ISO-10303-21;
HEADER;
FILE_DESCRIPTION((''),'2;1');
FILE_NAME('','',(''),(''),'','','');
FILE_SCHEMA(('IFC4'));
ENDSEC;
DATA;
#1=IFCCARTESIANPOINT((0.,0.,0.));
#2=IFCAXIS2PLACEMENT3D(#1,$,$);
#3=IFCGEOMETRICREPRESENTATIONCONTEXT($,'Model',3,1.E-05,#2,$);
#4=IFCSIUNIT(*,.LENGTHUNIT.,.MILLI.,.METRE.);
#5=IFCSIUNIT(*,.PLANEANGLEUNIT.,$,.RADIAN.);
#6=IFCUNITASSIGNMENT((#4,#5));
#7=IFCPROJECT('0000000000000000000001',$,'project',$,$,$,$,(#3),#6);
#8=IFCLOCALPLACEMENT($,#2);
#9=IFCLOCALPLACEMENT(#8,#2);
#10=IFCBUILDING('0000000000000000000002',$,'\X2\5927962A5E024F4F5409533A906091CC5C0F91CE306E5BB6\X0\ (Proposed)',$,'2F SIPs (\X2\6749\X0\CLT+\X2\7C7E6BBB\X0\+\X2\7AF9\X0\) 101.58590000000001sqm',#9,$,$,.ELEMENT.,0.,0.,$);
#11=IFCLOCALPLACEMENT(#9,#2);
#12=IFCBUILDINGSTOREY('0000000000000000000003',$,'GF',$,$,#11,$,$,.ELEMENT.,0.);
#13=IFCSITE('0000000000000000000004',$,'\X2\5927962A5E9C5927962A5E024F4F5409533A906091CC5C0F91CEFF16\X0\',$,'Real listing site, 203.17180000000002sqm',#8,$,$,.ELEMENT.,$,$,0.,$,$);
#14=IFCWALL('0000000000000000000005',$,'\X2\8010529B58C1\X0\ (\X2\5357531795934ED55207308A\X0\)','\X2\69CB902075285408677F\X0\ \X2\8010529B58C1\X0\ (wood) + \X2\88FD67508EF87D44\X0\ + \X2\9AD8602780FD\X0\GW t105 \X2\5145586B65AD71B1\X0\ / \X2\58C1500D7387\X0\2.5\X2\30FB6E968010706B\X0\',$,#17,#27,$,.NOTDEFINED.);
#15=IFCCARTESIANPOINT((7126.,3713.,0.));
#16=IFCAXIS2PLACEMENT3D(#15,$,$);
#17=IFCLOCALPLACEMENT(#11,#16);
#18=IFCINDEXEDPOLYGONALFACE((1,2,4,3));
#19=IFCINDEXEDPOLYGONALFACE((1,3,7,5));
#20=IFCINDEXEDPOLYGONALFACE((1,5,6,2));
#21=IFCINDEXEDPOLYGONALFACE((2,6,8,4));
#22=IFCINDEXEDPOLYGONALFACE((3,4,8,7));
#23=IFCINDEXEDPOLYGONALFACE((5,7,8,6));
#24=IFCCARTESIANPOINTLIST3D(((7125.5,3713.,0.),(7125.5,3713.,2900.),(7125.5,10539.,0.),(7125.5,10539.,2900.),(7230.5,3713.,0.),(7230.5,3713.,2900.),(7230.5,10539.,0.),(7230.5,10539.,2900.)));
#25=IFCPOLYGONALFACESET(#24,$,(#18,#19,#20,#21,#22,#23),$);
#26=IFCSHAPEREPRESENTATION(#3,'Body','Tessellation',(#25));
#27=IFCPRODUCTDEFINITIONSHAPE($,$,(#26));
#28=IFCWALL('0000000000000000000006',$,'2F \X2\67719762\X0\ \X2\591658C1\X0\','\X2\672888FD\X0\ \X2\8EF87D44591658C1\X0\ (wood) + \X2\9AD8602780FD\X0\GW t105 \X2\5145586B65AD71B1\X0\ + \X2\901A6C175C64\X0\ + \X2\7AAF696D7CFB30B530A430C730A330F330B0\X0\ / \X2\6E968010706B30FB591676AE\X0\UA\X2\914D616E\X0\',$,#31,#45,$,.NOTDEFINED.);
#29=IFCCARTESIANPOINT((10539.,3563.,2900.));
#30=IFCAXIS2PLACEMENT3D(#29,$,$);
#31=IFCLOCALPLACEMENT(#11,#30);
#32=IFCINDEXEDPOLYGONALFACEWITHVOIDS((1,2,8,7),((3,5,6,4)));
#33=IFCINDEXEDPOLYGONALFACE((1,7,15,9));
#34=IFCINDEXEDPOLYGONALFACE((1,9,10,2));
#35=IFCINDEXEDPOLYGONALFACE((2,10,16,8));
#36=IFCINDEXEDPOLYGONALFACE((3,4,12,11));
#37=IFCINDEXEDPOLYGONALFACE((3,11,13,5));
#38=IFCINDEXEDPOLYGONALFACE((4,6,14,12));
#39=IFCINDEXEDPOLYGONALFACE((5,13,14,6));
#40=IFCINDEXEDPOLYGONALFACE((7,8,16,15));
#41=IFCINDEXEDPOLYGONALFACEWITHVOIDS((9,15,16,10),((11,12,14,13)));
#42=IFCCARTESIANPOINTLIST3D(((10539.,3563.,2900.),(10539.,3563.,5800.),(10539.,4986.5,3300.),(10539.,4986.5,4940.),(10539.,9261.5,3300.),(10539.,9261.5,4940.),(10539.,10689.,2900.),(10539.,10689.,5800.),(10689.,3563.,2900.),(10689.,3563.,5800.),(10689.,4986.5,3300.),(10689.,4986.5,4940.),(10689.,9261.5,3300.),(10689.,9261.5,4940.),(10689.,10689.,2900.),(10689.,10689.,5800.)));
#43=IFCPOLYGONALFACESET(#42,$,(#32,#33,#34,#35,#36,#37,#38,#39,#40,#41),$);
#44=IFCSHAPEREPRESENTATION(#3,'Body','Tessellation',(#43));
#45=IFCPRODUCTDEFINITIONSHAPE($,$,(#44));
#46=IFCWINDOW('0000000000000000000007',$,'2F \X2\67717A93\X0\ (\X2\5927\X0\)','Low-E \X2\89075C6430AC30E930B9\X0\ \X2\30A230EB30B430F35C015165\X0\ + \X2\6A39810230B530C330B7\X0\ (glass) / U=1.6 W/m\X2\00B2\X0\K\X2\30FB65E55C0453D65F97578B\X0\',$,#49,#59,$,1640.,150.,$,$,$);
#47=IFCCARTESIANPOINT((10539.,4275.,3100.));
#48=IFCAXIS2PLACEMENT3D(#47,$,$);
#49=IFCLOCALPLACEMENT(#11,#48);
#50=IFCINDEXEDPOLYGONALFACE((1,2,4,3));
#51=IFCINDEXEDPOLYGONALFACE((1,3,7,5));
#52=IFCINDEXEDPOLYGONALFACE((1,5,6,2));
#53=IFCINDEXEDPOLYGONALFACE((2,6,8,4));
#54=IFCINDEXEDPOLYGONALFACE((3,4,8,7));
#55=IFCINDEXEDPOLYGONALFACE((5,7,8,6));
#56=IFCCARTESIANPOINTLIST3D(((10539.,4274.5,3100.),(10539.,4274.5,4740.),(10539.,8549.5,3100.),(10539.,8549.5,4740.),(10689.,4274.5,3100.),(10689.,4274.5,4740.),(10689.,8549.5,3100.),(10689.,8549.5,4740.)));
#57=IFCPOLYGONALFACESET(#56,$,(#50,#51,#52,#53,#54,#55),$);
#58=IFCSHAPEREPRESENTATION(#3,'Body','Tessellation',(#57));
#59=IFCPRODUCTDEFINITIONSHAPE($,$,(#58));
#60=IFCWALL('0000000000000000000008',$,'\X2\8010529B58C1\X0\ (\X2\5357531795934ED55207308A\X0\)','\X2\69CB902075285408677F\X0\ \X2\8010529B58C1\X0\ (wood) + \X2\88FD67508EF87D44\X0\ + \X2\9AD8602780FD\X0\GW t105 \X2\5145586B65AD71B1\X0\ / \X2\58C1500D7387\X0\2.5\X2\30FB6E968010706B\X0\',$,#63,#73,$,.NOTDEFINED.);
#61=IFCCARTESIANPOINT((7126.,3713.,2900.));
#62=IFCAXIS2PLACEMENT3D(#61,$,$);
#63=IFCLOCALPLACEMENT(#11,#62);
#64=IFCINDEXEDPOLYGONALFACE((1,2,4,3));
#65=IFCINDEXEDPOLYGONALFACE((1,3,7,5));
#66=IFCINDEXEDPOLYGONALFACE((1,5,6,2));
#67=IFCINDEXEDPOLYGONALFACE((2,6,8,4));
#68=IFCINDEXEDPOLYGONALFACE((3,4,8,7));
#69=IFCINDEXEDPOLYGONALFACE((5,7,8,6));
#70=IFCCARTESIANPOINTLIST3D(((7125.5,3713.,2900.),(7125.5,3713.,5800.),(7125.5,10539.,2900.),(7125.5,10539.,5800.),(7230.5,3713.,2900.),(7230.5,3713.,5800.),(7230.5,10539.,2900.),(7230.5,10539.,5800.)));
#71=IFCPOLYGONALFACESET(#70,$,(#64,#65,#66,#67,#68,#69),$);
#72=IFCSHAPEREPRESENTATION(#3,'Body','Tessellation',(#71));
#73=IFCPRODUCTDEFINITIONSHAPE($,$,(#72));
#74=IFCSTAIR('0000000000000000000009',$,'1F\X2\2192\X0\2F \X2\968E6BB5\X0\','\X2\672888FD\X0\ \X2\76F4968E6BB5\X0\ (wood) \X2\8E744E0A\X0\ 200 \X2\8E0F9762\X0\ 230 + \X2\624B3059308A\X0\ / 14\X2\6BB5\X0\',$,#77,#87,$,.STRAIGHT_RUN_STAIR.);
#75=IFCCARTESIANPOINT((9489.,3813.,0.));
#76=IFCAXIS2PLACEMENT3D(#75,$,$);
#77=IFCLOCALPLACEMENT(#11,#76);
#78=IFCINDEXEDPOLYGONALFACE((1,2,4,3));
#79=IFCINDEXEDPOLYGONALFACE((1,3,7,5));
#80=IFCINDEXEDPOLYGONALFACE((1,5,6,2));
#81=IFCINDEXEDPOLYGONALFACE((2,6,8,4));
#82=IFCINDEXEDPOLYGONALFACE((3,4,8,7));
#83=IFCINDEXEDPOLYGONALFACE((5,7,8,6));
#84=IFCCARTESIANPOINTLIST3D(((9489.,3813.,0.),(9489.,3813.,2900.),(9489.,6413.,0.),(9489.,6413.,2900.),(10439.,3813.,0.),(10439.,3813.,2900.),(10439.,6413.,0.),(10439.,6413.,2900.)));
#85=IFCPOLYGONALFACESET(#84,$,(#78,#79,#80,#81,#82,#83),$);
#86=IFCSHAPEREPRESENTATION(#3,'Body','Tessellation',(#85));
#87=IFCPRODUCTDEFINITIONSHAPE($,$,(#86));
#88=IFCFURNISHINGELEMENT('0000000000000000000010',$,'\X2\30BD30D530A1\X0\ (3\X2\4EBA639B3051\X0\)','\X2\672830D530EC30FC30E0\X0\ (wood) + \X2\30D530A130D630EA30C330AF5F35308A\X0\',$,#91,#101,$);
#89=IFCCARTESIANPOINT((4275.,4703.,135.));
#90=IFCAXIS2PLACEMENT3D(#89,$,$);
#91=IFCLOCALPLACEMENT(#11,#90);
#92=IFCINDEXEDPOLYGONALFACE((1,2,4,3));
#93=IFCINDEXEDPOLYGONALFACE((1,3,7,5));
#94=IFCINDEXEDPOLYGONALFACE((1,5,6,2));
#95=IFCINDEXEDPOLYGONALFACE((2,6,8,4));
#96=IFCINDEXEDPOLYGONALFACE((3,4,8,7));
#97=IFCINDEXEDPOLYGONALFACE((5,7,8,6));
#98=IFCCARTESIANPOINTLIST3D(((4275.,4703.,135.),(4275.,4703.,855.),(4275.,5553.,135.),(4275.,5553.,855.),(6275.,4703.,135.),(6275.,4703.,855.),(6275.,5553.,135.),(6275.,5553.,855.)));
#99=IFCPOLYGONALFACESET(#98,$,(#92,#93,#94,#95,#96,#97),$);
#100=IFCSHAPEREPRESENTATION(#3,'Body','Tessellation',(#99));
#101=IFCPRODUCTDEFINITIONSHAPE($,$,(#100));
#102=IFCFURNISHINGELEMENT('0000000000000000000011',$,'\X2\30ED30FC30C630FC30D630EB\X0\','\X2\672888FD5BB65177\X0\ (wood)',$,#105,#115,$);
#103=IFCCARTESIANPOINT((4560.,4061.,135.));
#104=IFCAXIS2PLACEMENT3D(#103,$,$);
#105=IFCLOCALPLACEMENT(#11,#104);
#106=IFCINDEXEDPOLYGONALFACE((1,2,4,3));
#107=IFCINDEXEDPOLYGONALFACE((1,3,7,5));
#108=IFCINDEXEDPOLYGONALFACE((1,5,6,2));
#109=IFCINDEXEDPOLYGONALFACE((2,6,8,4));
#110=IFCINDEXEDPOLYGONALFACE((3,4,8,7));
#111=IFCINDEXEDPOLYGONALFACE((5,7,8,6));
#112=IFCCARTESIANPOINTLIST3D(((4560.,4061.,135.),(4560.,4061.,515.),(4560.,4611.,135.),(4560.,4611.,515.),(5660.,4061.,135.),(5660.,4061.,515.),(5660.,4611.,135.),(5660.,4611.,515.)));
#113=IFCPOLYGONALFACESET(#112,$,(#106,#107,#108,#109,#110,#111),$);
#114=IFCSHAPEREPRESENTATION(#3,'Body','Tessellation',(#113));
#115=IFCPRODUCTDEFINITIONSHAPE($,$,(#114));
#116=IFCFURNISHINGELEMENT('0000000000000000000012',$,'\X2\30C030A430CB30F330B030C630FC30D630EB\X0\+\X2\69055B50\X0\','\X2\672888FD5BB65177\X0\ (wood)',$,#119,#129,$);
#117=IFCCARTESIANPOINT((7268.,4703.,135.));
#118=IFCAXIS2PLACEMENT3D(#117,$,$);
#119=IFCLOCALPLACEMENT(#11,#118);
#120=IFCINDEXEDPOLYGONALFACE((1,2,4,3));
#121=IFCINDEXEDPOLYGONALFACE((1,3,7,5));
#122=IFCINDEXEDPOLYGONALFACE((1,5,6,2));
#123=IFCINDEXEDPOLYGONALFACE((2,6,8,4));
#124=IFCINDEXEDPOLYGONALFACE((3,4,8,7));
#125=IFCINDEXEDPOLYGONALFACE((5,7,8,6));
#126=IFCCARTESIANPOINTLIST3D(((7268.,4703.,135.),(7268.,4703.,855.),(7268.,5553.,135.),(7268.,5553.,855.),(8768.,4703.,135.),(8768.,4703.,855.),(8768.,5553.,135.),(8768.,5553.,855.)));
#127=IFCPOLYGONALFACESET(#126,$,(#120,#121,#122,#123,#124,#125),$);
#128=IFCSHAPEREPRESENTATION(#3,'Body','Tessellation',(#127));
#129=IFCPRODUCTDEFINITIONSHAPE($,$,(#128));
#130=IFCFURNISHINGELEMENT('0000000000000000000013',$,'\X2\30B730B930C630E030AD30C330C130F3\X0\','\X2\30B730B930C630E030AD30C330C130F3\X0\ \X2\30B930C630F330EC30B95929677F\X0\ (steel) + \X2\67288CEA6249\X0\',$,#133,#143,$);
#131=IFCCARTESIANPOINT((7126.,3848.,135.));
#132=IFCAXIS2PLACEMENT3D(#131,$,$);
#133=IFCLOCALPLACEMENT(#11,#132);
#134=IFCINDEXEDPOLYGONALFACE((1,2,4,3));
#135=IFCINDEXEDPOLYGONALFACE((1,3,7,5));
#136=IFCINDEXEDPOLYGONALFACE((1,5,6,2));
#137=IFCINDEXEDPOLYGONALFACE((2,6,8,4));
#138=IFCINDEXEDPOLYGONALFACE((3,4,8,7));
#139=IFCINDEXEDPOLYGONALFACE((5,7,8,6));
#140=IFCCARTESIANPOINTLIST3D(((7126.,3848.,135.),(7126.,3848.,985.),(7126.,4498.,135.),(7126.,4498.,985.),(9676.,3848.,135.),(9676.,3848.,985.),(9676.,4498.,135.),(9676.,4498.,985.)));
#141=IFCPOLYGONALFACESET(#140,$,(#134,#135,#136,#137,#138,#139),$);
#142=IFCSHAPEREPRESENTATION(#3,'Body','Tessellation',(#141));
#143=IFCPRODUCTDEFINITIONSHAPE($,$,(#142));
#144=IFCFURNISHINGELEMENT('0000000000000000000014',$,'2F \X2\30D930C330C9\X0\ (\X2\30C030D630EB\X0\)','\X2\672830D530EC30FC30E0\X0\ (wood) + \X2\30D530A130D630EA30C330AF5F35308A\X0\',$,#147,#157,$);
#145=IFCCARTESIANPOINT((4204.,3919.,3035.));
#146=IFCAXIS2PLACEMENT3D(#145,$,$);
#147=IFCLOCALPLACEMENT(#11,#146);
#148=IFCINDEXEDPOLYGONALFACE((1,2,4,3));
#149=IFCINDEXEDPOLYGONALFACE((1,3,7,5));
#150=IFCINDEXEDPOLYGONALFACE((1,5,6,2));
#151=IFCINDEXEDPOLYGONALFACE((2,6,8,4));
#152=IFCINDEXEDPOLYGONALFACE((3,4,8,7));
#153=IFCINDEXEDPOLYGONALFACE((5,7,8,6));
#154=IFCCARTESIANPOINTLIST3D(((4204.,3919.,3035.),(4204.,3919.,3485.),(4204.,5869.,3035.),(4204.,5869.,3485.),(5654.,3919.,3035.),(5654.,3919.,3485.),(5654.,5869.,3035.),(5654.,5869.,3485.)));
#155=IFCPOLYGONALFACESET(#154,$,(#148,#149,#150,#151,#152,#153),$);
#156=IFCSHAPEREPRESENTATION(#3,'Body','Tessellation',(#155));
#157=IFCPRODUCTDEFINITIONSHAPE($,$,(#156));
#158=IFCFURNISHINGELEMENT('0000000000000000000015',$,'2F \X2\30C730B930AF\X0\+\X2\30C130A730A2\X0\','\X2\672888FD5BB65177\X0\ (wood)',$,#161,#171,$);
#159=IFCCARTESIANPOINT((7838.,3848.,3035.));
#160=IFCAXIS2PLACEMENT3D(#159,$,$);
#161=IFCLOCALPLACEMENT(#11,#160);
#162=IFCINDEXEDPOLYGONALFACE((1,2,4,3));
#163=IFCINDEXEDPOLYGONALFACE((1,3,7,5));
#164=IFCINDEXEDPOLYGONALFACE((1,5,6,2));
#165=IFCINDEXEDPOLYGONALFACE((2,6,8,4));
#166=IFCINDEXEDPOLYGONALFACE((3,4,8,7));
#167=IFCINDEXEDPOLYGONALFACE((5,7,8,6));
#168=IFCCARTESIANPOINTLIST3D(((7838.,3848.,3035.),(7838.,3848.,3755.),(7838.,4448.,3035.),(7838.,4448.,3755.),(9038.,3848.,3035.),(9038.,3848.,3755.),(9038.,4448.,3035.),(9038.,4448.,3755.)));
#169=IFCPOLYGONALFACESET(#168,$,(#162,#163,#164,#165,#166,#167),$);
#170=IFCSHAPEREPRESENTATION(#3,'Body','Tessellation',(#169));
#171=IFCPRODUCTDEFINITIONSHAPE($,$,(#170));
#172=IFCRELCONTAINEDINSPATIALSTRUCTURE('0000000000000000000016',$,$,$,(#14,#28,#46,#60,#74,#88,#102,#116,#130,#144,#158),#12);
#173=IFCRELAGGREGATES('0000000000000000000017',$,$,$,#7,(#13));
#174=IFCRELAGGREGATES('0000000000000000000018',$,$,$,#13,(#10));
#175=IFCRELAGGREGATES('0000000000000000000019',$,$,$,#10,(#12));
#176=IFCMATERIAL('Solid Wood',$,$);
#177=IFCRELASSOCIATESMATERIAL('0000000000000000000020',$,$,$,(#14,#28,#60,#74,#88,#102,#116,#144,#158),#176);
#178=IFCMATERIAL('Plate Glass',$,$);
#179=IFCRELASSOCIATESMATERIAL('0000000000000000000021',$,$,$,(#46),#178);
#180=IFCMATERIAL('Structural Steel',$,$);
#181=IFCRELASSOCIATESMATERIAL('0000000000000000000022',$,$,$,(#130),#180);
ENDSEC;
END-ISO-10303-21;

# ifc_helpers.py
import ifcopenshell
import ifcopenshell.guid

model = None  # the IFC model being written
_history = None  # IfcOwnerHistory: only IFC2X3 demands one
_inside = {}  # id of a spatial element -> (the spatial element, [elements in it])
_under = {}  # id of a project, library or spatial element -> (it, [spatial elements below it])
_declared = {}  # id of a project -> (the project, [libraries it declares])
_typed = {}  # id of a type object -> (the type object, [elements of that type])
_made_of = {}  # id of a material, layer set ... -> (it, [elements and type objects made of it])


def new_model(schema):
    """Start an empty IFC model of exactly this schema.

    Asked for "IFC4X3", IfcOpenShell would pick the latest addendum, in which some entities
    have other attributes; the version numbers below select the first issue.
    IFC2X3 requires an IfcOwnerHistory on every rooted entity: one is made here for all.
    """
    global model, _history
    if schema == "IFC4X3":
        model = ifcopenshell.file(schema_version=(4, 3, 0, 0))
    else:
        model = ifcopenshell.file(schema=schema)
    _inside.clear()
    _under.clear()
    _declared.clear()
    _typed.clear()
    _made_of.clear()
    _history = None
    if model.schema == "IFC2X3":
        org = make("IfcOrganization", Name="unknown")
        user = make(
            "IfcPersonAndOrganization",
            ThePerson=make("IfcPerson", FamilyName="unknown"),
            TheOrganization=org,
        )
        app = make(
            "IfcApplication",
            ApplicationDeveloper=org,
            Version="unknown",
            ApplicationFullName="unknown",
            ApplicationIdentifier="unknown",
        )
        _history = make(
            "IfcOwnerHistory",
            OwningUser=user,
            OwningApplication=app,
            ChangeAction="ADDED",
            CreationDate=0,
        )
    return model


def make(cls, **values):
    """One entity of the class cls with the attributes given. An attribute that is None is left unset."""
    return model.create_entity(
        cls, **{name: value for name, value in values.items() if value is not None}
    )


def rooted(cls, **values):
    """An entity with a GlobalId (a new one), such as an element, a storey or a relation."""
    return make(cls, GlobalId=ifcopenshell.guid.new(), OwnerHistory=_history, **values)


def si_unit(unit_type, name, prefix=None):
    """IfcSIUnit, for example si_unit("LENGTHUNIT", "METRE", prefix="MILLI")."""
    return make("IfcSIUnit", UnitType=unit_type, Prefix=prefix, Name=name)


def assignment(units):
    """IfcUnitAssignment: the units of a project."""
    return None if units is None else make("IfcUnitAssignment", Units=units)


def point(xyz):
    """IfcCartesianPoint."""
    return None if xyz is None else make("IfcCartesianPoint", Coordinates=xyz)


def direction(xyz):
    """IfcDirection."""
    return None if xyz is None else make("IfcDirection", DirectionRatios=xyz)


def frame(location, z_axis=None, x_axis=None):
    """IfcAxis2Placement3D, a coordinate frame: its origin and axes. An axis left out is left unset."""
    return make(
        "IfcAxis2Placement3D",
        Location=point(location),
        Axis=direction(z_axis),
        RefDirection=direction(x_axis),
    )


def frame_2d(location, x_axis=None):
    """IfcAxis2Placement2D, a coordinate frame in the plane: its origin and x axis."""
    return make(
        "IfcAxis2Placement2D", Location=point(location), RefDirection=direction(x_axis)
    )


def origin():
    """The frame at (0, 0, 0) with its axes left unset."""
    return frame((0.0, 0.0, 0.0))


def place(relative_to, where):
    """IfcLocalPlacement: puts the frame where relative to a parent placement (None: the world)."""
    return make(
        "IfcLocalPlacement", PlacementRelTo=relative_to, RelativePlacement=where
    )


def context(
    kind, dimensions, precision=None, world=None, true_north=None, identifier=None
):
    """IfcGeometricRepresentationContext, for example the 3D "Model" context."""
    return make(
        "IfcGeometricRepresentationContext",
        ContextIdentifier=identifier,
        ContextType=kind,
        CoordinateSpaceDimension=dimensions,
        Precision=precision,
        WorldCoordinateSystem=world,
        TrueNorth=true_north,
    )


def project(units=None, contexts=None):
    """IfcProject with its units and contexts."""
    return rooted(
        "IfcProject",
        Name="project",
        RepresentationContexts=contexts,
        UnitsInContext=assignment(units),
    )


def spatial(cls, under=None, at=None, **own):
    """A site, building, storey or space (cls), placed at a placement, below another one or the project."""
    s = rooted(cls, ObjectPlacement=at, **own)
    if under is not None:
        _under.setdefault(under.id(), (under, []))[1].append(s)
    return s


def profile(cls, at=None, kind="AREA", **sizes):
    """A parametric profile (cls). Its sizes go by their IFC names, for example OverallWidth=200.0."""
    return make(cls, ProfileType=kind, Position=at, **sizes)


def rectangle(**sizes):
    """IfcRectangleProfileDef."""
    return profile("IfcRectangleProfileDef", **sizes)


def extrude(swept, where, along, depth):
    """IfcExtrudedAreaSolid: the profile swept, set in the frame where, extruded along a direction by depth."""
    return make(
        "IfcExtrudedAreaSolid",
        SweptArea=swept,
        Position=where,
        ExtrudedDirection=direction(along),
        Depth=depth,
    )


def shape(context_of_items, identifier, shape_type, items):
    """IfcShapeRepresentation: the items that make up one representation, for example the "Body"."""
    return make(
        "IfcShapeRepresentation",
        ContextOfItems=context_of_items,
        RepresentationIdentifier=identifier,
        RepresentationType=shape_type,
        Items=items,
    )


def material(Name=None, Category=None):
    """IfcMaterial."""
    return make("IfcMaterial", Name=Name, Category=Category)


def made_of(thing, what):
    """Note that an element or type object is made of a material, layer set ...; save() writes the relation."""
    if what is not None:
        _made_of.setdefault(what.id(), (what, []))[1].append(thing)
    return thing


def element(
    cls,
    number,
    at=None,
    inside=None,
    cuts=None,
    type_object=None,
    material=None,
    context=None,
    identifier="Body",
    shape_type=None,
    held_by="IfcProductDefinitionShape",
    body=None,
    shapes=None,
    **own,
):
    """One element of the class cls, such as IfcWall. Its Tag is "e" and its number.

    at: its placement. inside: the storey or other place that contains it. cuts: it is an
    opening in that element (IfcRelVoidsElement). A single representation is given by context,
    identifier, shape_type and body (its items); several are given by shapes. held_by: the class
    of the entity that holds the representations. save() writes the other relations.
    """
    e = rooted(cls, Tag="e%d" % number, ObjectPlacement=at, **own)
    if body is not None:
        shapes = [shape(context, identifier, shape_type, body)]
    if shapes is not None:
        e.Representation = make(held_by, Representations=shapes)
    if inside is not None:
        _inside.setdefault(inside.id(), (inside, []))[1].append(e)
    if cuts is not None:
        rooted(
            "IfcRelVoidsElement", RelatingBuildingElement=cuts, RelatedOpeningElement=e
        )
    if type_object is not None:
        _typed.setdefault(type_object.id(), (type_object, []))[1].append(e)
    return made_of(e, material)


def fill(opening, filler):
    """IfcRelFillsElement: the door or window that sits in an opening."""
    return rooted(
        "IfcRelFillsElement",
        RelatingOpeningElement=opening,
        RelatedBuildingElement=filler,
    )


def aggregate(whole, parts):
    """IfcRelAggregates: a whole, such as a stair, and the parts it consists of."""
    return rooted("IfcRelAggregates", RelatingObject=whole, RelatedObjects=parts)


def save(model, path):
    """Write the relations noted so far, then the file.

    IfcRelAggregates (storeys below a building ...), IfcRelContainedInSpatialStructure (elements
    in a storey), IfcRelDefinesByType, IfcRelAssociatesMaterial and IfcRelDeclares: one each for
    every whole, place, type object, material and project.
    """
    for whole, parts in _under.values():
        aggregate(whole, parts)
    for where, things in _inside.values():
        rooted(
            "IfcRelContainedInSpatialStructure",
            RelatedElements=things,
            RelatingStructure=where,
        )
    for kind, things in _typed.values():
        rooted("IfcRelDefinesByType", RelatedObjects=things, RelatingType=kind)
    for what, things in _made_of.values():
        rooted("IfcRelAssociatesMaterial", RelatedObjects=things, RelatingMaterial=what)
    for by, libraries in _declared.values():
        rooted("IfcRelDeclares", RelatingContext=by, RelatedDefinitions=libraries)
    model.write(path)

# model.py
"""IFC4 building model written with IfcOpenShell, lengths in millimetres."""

from ifc_helpers import new_model, si_unit, frame, frame_2d, origin, place, context, project, spatial, rectangle, extrude, material, element, fill, save


model = new_model("IFC4")

# Units and contexts
model_context = context("Model", 3, precision=1e-05, world=origin())
ifc_project = project(units=[si_unit("LENGTHUNIT", "METRE", prefix="MILLI"), si_unit("PLANEANGLEUNIT", "RADIAN")], contexts=[model_context])

# Site, building, storey
site_placement = place(None, origin())
site = spatial("IfcSite", under=ifc_project, at=site_placement, Name="大阪府大阪市住吉区遠里小野６", ObjectType="Real listing site, 203.17180000000002sqm", CompositionType="ELEMENT", RefElevation=0.0)
building_placement = place(site_placement, origin())
building = spatial("IfcBuilding", under=site, at=building_placement, Name="大阪市住吉区遠里小野の家 (Proposed)", ObjectType="2F SIPs (杉CLT+籾殻+竹) 101.58590000000001sqm", CompositionType="ELEMENT", ElevationOfRefHeight=0.0, ElevationOfTerrain=0.0)
storey_placement = place(building_placement, origin())
storey = spatial("IfcBuildingStorey", under=building, at=storey_placement, Name="GF", CompositionType="ELEMENT", Elevation=0.0)

# Shared definitions
ifc_material_1 = material(Name="Solid Wood")
ifc_material_2 = material(Name="Plate Glass")

# Wall
wall_1_placement = place(storey_placement, frame((7126.0, 3713.0, 0.0)))
element("IfcWall", 1, at=wall_1_placement, inside=storey, material=ifc_material_1, Name="耐力壁 (南北間仕切り)", Description="構造用合板 耐力壁 (wood) + 製材軸組 + 高性能GW t105 充填断熱 / 壁倍率2.5・準耐火", PredefinedType="NOTDEFINED", context=model_context, shape_type="SweptSolid", body=[
    extrude(rectangle(XDim=105.0, YDim=6826.0, at=frame_2d((52.0, 3413.0))), frame((7126.0, 3713.0, 0.0)), (0.0, 0.0, 1.0), 2900.0),
])

# Wall, opening, window
wall_2_placement = place(storey_placement, frame((10539.0, 3563.0, 2900.0)))
wall_2 = element("IfcWall", 2, at=wall_2_placement, inside=storey, material=ifc_material_1, Name="2F 東面 外壁", Description="木製 軸組外壁 (wood) + 高性能GW t105 充填断熱 + 通気層 + 窯業系サイディング / 準耐火・外皮UA配慮", PredefinedType="NOTDEFINED", context=model_context, shape_type="SweptSolid", body=[
    extrude(rectangle(XDim=150.0, YDim=7126.0, at=frame_2d((75.0, 3563.0))), frame((10539.0, 3563.0, 2900.0)), (0.0, 0.0, 1.0), 2900.0),
])
opening_1_placement = place(storey_placement, frame((10539.0, 4275.0, 3100.0)))
opening_1 = element("IfcOpeningElement", 3, at=opening_1_placement, cuts=wall_2, PredefinedType="NOTDEFINED", context=model_context, shape_type="SweptSolid", body=[
    extrude(rectangle(XDim=150.0, YDim=4275.0, at=frame_2d((75.0, 2137.0))), frame((10539.0, 4275.0, 3100.0)), (0.0, 0.0, 1.0), 1640.0),
])
window_1_placement = place(storey_placement, frame((10539.0, 4275.0, 3100.0)))
window_1 = element("IfcWindow", 4, at=window_1_placement, inside=storey, material=ifc_material_2, Name="2F 東窓 (大)", Description="Low-E 複層ガラス アルゴン封入 + 樹脂サッシ (glass) / U=1.6 W/m²K・日射取得型", OverallHeight=1640.0, OverallWidth=150.0, context=model_context, shape_type="SweptSolid", body=[
    extrude(rectangle(XDim=150.0, YDim=4275.0, at=frame_2d((75.0, 2137.0))), frame((10539.0, 4275.0, 3100.0)), (0.0, 0.0, 1.0), 1640.0),
])
fill(opening_1, window_1)

# Wall
wall_3_placement = place(storey_placement, frame((7126.0, 3713.0, 2900.0)))
element("IfcWall", 5, at=wall_3_placement, inside=storey, material=ifc_material_1, Name="耐力壁 (南北間仕切り)", Description="構造用合板 耐力壁 (wood) + 製材軸組 + 高性能GW t105 充填断熱 / 壁倍率2.5・準耐火", PredefinedType="NOTDEFINED", context=model_context, shape_type="SweptSolid", body=[
    extrude(rectangle(XDim=105.0, YDim=6826.0, at=frame_2d((52.0, 3413.0))), frame((7126.0, 3713.0, 2900.0)), (0.0, 0.0, 1.0), 2900.0),
])

# Stair
stair_placement = place(storey_placement, frame((9489.0, 3813.0, 0.0)))
element("IfcStair", 6, at=stair_placement, inside=storey, material=ifc_material_1, Name="1F→2F 階段", Description="木製 直階段 (wood) 蹴上 200 踏面 230 + 手すり / 14段", PredefinedType="STRAIGHT_RUN_STAIR", context=model_context, shape_type="SweptSolid", body=[
    extrude(rectangle(XDim=950.0, YDim=2600.0, at=frame_2d((475.0, 1300.0))), frame((9489.0, 3813.0, 0.0)), (0.0, 0.0, 1.0), 2900.0),
])

# Furnishing elements
furnishing_1_placement = place(storey_placement, frame((4275.0, 4703.0, 135.0)))
element("IfcFurnishingElement", 7, at=furnishing_1_placement, inside=storey, material=ifc_material_1, Name="ソファ (3人掛け)", Description="木フレーム (wood) + ファブリック張り", context=model_context, shape_type="SweptSolid", body=[
    extrude(rectangle(XDim=2000.0, YDim=850.0, at=frame_2d((1000.0, 425.0))), frame((4275.0, 4703.0, 135.0)), (0.0, 0.0, 1.0), 720.0),
])
furnishing_2_placement = place(storey_placement, frame((4560.0, 4061.0, 135.0)))
element("IfcFurnishingElement", 8, at=furnishing_2_placement, inside=storey, material=ifc_material_1, Name="ローテーブル", Description="木製家具 (wood)", context=model_context, shape_type="SweptSolid", body=[
    extrude(rectangle(XDim=1100.0, YDim=550.0, at=frame_2d((550.0, 275.0))), frame((4560.0, 4061.0, 135.0)), (0.0, 0.0, 1.0), 380.0),
])
furnishing_3_placement = place(storey_placement, frame((7268.0, 4703.0, 135.0)))
element("IfcFurnishingElement", 9, at=furnishing_3_placement, inside=storey, material=ifc_material_1, Name="ダイニングテーブル+椅子", Description="木製家具 (wood)", context=model_context, shape_type="SweptSolid", body=[
    extrude(rectangle(XDim=1500.0, YDim=850.0, at=frame_2d((750.0, 425.0))), frame((7268.0, 4703.0, 135.0)), (0.0, 0.0, 1.0), 720.0),
])
ifc_material_3 = material(Name="Structural Steel")
furnishing_4_placement = place(storey_placement, frame((7126.0, 3848.0, 135.0)))
element("IfcFurnishingElement", 10, at=furnishing_4_placement, inside=storey, material=ifc_material_3, Name="システムキッチン", Description="システムキッチン ステンレス天板 (steel) + 木質扉", context=model_context, shape_type="SweptSolid", body=[
    extrude(rectangle(XDim=2550.0, YDim=650.0, at=frame_2d((1275.0, 325.0))), frame((7126.0, 3848.0, 135.0)), (0.0, 0.0, 1.0), 850.0),
])
furnishing_5_placement = place(storey_placement, frame((4204.0, 3919.0, 3035.0)))
element("IfcFurnishingElement", 11, at=furnishing_5_placement, inside=storey, material=ifc_material_1, Name="2F ベッド (ダブル)", Description="木フレーム (wood) + ファブリック張り", context=model_context, shape_type="SweptSolid", body=[
    extrude(rectangle(XDim=1450.0, YDim=1950.0, at=frame_2d((725.0, 975.0))), frame((4204.0, 3919.0, 3035.0)), (0.0, 0.0, 1.0), 450.0),
])
furnishing_6_placement = place(storey_placement, frame((7838.0, 3848.0, 3035.0)))
element("IfcFurnishingElement", 12, at=furnishing_6_placement, inside=storey, material=ifc_material_1, Name="2F デスク+チェア", Description="木製家具 (wood)", context=model_context, shape_type="SweptSolid", body=[
    extrude(rectangle(XDim=1200.0, YDim=600.0, at=frame_2d((600.0, 300.0))), frame((7838.0, 3848.0, 3035.0)), (0.0, 0.0, 1.0), 720.0),
])

save(model, "model.ifc")
